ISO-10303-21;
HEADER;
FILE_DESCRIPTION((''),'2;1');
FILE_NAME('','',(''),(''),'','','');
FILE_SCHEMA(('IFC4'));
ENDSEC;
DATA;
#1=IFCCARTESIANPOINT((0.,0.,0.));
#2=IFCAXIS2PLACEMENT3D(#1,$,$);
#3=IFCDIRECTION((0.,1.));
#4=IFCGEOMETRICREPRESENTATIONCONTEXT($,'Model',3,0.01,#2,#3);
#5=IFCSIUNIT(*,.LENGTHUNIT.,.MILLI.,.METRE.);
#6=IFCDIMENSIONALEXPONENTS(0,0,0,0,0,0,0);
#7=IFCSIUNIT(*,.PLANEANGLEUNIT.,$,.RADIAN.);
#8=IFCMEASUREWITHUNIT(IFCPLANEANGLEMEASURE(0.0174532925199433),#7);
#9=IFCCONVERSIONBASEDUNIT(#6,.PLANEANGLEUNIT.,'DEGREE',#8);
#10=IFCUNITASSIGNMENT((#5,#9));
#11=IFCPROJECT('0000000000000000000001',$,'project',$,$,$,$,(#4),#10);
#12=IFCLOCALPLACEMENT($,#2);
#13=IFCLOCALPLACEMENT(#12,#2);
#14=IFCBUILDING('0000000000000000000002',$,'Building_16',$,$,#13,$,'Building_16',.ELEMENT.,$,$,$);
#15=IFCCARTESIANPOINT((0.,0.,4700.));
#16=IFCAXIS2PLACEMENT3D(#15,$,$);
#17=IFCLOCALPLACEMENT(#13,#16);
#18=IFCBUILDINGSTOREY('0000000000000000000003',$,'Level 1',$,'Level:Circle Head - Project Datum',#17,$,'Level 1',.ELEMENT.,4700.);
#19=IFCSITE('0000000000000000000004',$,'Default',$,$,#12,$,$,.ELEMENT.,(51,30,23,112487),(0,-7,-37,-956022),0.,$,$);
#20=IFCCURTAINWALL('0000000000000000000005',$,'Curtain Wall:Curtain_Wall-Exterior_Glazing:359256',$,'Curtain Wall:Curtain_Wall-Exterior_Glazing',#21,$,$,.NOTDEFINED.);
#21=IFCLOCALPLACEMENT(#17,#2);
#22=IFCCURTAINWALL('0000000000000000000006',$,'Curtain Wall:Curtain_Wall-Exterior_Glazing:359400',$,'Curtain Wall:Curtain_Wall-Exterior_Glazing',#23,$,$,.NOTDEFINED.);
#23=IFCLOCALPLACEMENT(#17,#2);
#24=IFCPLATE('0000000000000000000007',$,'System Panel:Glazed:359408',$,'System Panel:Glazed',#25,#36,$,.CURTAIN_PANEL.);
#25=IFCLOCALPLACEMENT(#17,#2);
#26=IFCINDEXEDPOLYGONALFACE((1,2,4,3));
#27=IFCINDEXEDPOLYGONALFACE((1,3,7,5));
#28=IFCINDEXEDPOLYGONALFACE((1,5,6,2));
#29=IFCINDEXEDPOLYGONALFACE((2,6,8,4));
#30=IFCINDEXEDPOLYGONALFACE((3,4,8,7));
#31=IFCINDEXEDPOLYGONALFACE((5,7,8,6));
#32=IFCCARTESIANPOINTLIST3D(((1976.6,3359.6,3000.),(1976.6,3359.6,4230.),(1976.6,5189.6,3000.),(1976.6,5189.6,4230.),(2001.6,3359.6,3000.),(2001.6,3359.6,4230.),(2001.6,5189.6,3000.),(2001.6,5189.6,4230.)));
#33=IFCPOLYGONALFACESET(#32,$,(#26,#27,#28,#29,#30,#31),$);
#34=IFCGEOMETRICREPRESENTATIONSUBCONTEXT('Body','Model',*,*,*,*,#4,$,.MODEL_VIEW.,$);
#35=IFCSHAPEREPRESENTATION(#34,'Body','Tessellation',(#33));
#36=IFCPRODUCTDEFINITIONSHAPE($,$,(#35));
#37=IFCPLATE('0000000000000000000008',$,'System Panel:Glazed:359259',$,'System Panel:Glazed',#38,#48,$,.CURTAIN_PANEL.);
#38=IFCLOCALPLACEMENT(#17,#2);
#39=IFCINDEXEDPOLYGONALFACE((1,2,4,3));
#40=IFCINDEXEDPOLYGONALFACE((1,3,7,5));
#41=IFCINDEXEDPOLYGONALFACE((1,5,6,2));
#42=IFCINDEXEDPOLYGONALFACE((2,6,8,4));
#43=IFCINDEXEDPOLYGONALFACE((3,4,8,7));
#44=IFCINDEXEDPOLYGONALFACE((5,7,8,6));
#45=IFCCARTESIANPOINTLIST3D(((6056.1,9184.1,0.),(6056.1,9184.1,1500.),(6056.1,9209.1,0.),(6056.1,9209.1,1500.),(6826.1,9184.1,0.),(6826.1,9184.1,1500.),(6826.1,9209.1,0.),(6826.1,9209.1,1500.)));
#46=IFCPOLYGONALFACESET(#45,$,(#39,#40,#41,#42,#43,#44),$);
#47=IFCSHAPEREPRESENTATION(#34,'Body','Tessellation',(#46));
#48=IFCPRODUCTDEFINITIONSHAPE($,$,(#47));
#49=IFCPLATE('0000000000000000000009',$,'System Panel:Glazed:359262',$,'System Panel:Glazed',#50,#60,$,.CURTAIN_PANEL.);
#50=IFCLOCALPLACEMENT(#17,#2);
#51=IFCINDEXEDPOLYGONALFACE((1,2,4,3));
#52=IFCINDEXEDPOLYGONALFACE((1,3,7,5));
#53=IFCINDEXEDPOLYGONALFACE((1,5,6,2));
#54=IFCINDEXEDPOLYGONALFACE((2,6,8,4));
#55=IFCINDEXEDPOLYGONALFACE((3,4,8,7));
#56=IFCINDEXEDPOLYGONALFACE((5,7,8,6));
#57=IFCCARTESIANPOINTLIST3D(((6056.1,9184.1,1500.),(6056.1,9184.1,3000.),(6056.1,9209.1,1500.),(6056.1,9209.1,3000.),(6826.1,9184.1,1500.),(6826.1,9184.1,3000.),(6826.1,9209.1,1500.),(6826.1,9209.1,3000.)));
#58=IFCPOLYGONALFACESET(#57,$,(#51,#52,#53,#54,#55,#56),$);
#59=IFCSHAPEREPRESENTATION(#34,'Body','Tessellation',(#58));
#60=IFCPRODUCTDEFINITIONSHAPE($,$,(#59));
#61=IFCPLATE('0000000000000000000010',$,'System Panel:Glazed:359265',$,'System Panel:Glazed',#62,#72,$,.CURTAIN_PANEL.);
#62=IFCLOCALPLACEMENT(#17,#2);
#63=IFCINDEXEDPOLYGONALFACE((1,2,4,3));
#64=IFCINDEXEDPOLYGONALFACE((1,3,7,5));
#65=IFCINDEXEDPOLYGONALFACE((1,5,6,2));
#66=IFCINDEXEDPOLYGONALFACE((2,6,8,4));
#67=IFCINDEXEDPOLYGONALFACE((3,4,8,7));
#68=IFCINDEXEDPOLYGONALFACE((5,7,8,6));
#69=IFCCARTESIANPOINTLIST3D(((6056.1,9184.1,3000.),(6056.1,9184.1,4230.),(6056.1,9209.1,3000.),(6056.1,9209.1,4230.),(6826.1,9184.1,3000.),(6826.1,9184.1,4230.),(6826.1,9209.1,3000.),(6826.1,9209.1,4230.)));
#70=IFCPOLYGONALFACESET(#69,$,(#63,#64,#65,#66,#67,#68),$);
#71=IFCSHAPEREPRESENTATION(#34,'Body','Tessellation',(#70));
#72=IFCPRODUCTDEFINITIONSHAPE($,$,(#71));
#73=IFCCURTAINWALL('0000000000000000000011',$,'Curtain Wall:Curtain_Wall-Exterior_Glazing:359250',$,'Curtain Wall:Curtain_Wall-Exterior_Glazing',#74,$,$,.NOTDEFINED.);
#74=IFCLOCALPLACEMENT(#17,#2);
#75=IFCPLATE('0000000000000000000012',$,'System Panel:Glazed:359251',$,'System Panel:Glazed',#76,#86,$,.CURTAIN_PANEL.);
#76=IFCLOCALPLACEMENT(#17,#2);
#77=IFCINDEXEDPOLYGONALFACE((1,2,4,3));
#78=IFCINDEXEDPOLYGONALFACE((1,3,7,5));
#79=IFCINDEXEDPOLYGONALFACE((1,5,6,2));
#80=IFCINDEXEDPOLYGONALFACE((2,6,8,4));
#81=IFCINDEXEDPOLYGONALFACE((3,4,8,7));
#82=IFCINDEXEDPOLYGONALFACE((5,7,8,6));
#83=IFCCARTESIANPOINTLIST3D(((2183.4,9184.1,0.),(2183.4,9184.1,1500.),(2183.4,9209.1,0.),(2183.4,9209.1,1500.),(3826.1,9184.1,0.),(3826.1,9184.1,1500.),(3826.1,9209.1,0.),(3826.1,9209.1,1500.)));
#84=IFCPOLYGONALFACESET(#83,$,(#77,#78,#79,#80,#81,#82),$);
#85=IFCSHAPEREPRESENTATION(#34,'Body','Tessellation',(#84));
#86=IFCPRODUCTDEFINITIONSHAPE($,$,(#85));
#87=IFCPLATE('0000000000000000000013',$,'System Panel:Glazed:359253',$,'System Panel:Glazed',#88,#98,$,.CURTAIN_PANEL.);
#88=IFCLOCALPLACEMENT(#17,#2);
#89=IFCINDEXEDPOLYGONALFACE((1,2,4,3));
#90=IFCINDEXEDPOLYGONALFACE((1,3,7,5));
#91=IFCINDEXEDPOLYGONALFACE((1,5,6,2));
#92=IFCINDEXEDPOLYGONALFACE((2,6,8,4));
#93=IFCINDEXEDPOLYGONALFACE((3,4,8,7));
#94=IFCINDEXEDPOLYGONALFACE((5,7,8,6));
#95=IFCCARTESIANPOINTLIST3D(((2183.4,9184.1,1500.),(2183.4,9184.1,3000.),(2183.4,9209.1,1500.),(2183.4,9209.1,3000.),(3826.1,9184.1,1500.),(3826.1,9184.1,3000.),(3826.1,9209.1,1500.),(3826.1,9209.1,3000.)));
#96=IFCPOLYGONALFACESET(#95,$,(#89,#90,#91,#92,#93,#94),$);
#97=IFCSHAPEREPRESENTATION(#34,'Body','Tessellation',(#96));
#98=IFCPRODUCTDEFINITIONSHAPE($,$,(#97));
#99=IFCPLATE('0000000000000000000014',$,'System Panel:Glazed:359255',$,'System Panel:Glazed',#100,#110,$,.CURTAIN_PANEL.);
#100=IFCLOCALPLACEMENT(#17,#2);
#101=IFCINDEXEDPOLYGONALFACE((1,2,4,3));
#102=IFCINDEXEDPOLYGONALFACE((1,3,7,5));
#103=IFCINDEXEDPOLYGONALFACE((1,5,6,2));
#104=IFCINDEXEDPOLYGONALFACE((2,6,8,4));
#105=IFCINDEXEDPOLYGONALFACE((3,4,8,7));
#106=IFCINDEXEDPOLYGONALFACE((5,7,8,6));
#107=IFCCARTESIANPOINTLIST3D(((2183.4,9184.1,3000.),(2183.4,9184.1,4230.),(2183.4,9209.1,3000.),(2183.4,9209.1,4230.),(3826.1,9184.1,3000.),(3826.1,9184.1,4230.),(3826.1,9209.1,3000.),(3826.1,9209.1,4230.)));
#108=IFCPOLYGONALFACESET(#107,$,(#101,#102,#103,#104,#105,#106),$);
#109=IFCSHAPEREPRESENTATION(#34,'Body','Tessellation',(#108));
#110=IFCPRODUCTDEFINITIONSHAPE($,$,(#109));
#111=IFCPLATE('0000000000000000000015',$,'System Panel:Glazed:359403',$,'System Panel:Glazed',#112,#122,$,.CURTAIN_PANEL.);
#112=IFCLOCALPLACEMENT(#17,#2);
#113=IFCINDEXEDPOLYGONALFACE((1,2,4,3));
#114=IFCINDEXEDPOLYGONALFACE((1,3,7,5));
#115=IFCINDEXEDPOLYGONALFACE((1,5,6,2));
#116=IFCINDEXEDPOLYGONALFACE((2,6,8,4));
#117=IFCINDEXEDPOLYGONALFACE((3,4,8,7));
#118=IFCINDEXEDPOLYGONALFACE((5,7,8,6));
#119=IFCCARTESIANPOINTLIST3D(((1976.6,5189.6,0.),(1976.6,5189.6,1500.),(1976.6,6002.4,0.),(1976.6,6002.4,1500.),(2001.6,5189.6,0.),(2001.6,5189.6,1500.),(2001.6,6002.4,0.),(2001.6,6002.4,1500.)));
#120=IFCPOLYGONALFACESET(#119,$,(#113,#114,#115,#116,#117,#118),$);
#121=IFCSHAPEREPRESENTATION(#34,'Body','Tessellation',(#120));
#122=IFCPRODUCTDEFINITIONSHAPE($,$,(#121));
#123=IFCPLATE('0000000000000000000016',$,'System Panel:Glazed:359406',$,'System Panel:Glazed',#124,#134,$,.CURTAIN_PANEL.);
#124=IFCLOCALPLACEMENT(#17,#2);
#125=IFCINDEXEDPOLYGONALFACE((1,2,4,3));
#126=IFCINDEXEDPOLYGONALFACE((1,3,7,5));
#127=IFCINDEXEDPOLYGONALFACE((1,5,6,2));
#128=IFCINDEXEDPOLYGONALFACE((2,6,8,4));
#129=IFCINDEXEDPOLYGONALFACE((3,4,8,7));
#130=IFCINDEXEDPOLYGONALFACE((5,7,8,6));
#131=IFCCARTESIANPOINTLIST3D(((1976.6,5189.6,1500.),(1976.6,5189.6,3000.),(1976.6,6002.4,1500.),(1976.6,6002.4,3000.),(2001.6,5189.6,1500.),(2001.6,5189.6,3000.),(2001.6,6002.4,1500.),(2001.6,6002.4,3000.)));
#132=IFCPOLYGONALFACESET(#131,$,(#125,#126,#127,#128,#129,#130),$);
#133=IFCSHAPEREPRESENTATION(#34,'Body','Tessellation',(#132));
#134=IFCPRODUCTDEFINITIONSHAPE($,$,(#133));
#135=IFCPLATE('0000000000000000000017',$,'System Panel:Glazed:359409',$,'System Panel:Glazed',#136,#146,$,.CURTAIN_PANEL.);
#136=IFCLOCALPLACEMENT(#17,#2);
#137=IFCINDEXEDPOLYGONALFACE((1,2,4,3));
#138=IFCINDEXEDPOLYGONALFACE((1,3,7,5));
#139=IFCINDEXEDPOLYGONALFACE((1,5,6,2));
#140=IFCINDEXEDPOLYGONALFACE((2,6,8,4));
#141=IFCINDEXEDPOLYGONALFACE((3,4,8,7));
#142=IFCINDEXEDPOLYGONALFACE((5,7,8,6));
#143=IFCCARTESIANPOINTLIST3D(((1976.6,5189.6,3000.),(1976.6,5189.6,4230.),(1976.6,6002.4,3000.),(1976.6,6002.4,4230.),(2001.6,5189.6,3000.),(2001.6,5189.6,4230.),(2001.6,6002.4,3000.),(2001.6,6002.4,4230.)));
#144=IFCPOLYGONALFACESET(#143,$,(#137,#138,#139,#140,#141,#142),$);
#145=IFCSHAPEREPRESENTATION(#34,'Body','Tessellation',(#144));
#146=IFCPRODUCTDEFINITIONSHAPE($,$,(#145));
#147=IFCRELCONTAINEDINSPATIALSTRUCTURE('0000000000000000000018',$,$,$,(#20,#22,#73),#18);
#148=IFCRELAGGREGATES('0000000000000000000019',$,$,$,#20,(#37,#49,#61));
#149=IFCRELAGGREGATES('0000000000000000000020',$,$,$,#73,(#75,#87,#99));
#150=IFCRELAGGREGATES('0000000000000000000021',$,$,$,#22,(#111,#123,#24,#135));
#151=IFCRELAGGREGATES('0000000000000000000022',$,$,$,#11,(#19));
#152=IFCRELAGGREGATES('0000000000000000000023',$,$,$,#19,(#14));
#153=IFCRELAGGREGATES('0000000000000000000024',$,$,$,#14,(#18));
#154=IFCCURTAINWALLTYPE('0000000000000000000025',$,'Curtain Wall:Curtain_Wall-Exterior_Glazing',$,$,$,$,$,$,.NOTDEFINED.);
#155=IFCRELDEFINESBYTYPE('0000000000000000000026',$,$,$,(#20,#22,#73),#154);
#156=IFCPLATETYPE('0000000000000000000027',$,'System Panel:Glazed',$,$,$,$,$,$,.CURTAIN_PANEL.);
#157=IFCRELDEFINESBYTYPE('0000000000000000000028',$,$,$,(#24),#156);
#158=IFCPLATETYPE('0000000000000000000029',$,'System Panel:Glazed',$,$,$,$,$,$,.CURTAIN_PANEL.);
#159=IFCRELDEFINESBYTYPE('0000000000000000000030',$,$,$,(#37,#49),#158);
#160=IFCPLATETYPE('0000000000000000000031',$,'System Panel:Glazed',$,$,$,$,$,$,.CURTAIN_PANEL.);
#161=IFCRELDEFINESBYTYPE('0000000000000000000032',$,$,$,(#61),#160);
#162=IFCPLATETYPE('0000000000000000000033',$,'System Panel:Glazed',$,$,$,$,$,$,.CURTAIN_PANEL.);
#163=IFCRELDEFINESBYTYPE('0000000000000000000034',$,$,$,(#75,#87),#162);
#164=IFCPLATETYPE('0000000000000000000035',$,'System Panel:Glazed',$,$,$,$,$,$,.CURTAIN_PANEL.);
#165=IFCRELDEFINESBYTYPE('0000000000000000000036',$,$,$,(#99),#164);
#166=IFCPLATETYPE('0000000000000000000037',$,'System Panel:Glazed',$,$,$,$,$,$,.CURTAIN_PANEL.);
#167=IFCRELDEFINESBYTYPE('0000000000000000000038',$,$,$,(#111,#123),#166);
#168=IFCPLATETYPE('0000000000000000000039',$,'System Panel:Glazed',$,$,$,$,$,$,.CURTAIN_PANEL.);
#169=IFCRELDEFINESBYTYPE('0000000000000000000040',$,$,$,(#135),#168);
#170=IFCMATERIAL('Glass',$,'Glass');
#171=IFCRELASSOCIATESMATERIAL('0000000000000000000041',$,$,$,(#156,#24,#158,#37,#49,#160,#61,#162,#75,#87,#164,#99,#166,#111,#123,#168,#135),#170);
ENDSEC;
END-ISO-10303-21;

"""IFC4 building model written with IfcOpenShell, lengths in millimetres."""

from ifc_helpers import new_model, entity, si_unit, converted_unit, direction, frame, origin, place, context, subcontext, project, spatial, indexed_curve, outline, extrude, source, transform, mapped, material, type_object, type_shapes, element, aggregate, save


model = new_model("IFC4")

# Units and contexts
model_context = context("Model", 3, precision=0.01, world=origin(), true_north=direction((0.0, 1.0)))
body_context = subcontext(model_context, "Body", "Model", "MODEL_VIEW")
ifc_project = project(units=[si_unit("LENGTHUNIT", "METRE", prefix="MILLI"), converted_unit("PLANEANGLEUNIT", "DEGREE", entity("IfcPlaneAngleMeasure", 0.0174532925199433), si_unit("PLANEANGLEUNIT", "RADIAN"), dimensions=[0, 0, 0, 0, 0, 0, 0])], contexts=[model_context])

# Site, building, storey
site_placement = place(None, origin())
site = spatial("IfcSite", under=ifc_project, at=site_placement, Name="Default", CompositionType="ELEMENT", RefLatitude=(51, 30, 23, 112487), RefLongitude=(0, -7, -37, -956022), RefElevation=0.0)
building_placement = place(site_placement, origin())
building = spatial("IfcBuilding", under=site, at=building_placement, Name="Building_16", LongName="Building_16", CompositionType="ELEMENT")
storey_placement = place(building_placement, frame((0.0, 0.0, 4700.0)))
storey = spatial("IfcBuildingStorey", under=building, at=storey_placement, Name="Level 1", ObjectType="Level:Circle Head - Project Datum", LongName="Level 1", CompositionType="ELEMENT", Elevation=4700.0)

# Curtain wall
curtain_wall_type = type_object("IfcCurtainWallType", Name="Curtain Wall:Curtain_Wall-Exterior_Glazing", PredefinedType="NOTDEFINED")
curtain_wall_1_placement = place(storey_placement, frame((0.0, 0.0, -4700.0)))
curtain_wall_1 = element("IfcCurtainWall", 1, at=curtain_wall_1_placement, inside=storey, type_object=curtain_wall_type, Name="Curtain Wall:Curtain_Wall-Exterior_Glazing:359256", ObjectType="Curtain Wall:Curtain_Wall-Exterior_Glazing", PredefinedType="NOTDEFINED")
ifc_material_1 = material(Name="Glass", Category="Glass")

# Shared definitions
plate_type_1 = type_object("IfcPlateType", Name="System Panel:Glazed", PredefinedType="CURTAIN_PANEL", material=ifc_material_1)
shared_shape_1 = source(origin(), body_context, "Body", "SweptSolid", [
    extrude(outline(indexed_curve([(-12.5, -915.0), (12.5, -915.0), (12.5, 915.0), (-12.5, 915.0), (-12.5, -915.0)], self_intersect=False)), frame((0.0, 37.0, 0.0), z_axis=(0.0, 0.0, 1.0), x_axis=(0.0, 1.0, 0.0)), (0.0, 0.0, 1.0), 1230.0),
])
type_shapes(plate_type_1, [shared_shape_1])

# Curtain wall, plate
curtain_wall_2_placement = place(storey_placement, frame((0.0, 0.0, -4700.0)))
curtain_wall_2 = element("IfcCurtainWall", 2, at=curtain_wall_2_placement, inside=storey, type_object=curtain_wall_type, Name="Curtain Wall:Curtain_Wall-Exterior_Glazing:359400", ObjectType="Curtain Wall:Curtain_Wall-Exterior_Glazing", PredefinedType="NOTDEFINED")
plate_1_placement = place(curtain_wall_2_placement, frame((2026.1, 4274.6, 7700.0), z_axis=(0.0, 0.0, 1.0), x_axis=(0.0, 1.0, 0.0)))
plate_1 = element("IfcPlate", 3, at=plate_1_placement, type_object=plate_type_1, material=ifc_material_1, Name="System Panel:Glazed:359408", ObjectType="System Panel:Glazed", PredefinedType="CURTAIN_PANEL", context=body_context, shape_type="MappedRepresentation", body=[
    mapped(shared_shape_1, transform((0.0, 0.0, 0.0), scale=1.0)),
])

# Plates
plate_type_2 = type_object("IfcPlateType", Name="System Panel:Glazed", PredefinedType="CURTAIN_PANEL", material=ifc_material_1)
shared_shape_2 = source(origin(), body_context, "Body", "SweptSolid", [
    extrude(outline(indexed_curve([(-12.5, -385.0), (12.5, -385.0), (12.5, 385.0), (-12.5, 385.0), (-12.5, -385.0)], self_intersect=False)), frame((0.0, 37.0, 0.0), z_axis=(0.0, 0.0, 1.0), x_axis=(0.0, 1.0, 0.0)), (0.0, 0.0, 1.0), 1500.0),
])
type_shapes(plate_type_2, [shared_shape_2])
plate_2_placement = place(curtain_wall_1_placement, frame((6441.1, 9159.6, 4700.0)))
plate_2 = element("IfcPlate", 4, at=plate_2_placement, type_object=plate_type_2, material=ifc_material_1, Name="System Panel:Glazed:359259", ObjectType="System Panel:Glazed", PredefinedType="CURTAIN_PANEL", context=body_context, shape_type="MappedRepresentation", body=[
    mapped(shared_shape_2, transform((0.0, 0.0, 0.0), scale=1.0)),
])
plate_3_placement = place(curtain_wall_1_placement, frame((6441.1, 9159.6, 6200.0)))
plate_3 = element("IfcPlate", 5, at=plate_3_placement, type_object=plate_type_2, material=ifc_material_1, Name="System Panel:Glazed:359262", ObjectType="System Panel:Glazed", PredefinedType="CURTAIN_PANEL", context=body_context, shape_type="MappedRepresentation", body=[
    mapped(shared_shape_2, transform((0.0, 0.0, 0.0), scale=1.0)),
])
plate_type_3 = type_object("IfcPlateType", Name="System Panel:Glazed", PredefinedType="CURTAIN_PANEL", material=ifc_material_1)
shared_shape_3 = source(origin(), body_context, "Body", "SweptSolid", [
    extrude(outline(indexed_curve([(-12.5, -385.0), (12.5, -385.0), (12.5, 385.0), (-12.5, 385.0), (-12.5, -385.0)], self_intersect=False)), frame((0.0, 37.0, 0.0), z_axis=(0.0, 0.0, 1.0), x_axis=(0.0, 1.0, 0.0)), (0.0, 0.0, 1.0), 1230.0),
])
type_shapes(plate_type_3, [shared_shape_3])
plate_4_placement = place(curtain_wall_1_placement, frame((6441.1, 9159.6, 7700.0)))
plate_4 = element("IfcPlate", 6, at=plate_4_placement, type_object=plate_type_3, material=ifc_material_1, Name="System Panel:Glazed:359265", ObjectType="System Panel:Glazed", PredefinedType="CURTAIN_PANEL", context=body_context, shape_type="MappedRepresentation", body=[
    mapped(shared_shape_3, transform((0.0, 0.0, 0.0), scale=1.0)),
])
aggregate(curtain_wall_1, [plate_2, plate_3, plate_4])

# Curtain wall, plates
curtain_wall_3_placement = place(storey_placement, frame((0.0, 0.0, -4700.0)))
curtain_wall_3 = element("IfcCurtainWall", 7, at=curtain_wall_3_placement, inside=storey, type_object=curtain_wall_type, Name="Curtain Wall:Curtain_Wall-Exterior_Glazing:359250", ObjectType="Curtain Wall:Curtain_Wall-Exterior_Glazing", PredefinedType="NOTDEFINED")
plate_type_4 = type_object("IfcPlateType", Name="System Panel:Glazed", PredefinedType="CURTAIN_PANEL", material=ifc_material_1)
shared_shape_4 = source(origin(), body_context, "Body", "SweptSolid", [
    extrude(outline(indexed_curve([(-12.5, -821.4), (12.5, -821.4), (12.5, 821.4), (-12.5, 821.4), (-12.5, -821.4)], self_intersect=False)), frame((0.0, 37.0, 0.0), z_axis=(0.0, 0.0, 1.0), x_axis=(0.0, 1.0, 0.0)), (0.0, 0.0, 1.0), 1500.0),
])
type_shapes(plate_type_4, [shared_shape_4])
plate_5_placement = place(curtain_wall_3_placement, frame((3004.7, 9159.6, 4700.0)))
plate_5 = element("IfcPlate", 8, at=plate_5_placement, type_object=plate_type_4, material=ifc_material_1, Name="System Panel:Glazed:359251", ObjectType="System Panel:Glazed", PredefinedType="CURTAIN_PANEL", context=body_context, shape_type="MappedRepresentation", body=[
    mapped(shared_shape_4, transform((0.0, 0.0, 0.0), scale=1.0)),
])
plate_6_placement = place(curtain_wall_3_placement, frame((3004.7, 9159.6, 6200.0)))
plate_6 = element("IfcPlate", 9, at=plate_6_placement, type_object=plate_type_4, material=ifc_material_1, Name="System Panel:Glazed:359253", ObjectType="System Panel:Glazed", PredefinedType="CURTAIN_PANEL", context=body_context, shape_type="MappedRepresentation", body=[
    mapped(shared_shape_4, transform((0.0, 0.0, 0.0), scale=1.0)),
])
plate_type_5 = type_object("IfcPlateType", Name="System Panel:Glazed", PredefinedType="CURTAIN_PANEL", material=ifc_material_1)
shared_shape_5 = source(origin(), body_context, "Body", "SweptSolid", [
    extrude(outline(indexed_curve([(-12.5, -821.4), (12.5, -821.4), (12.5, 821.4), (-12.5, 821.4), (-12.5, -821.4)], self_intersect=False)), frame((0.0, 37.0, 0.0), z_axis=(0.0, 0.0, 1.0), x_axis=(0.0, 1.0, 0.0)), (0.0, 0.0, 1.0), 1230.0),
])
type_shapes(plate_type_5, [shared_shape_5])
plate_7_placement = place(curtain_wall_3_placement, frame((3004.7, 9159.6, 7700.0)))
plate_7 = element("IfcPlate", 10, at=plate_7_placement, type_object=plate_type_5, material=ifc_material_1, Name="System Panel:Glazed:359255", ObjectType="System Panel:Glazed", PredefinedType="CURTAIN_PANEL", context=body_context, shape_type="MappedRepresentation", body=[
    mapped(shared_shape_5, transform((0.0, 0.0, 0.0), scale=1.0)),
])
aggregate(curtain_wall_3, [plate_5, plate_6, plate_7])

# Plates
plate_type_6 = type_object("IfcPlateType", Name="System Panel:Glazed", PredefinedType="CURTAIN_PANEL", material=ifc_material_1)
shared_shape_6 = source(origin(), body_context, "Body", "SweptSolid", [
    extrude(outline(indexed_curve([(-12.5, -406.4), (12.5, -406.4), (12.5, 406.4), (-12.5, 406.4), (-12.5, -406.4)], self_intersect=False)), frame((0.0, 37.0, 0.0), z_axis=(0.0, 0.0, 1.0), x_axis=(0.0, 1.0, 0.0)), (0.0, 0.0, 1.0), 1500.0),
])
type_shapes(plate_type_6, [shared_shape_6])
plate_8_placement = place(curtain_wall_2_placement, frame((2026.1, 5596.0, 4700.0), z_axis=(0.0, 0.0, 1.0), x_axis=(0.0, 1.0, 0.0)))
plate_8 = element("IfcPlate", 11, at=plate_8_placement, type_object=plate_type_6, material=ifc_material_1, Name="System Panel:Glazed:359403", ObjectType="System Panel:Glazed", PredefinedType="CURTAIN_PANEL", context=body_context, shape_type="MappedRepresentation", body=[
    mapped(shared_shape_6, transform((0.0, 0.0, 0.0), scale=1.0)),
])
plate_9_placement = place(curtain_wall_2_placement, frame((2026.1, 5596.0, 6200.0), z_axis=(0.0, 0.0, 1.0), x_axis=(0.0, 1.0, 0.0)))
plate_9 = element("IfcPlate", 12, at=plate_9_placement, type_object=plate_type_6, material=ifc_material_1, Name="System Panel:Glazed:359406", ObjectType="System Panel:Glazed", PredefinedType="CURTAIN_PANEL", context=body_context, shape_type="MappedRepresentation", body=[
    mapped(shared_shape_6, transform((0.0, 0.0, 0.0), scale=1.0)),
])
plate_type_7 = type_object("IfcPlateType", Name="System Panel:Glazed", PredefinedType="CURTAIN_PANEL", material=ifc_material_1)
shared_shape_7 = source(origin(), body_context, "Body", "SweptSolid", [
    extrude(outline(indexed_curve([(-12.5, -406.4), (12.5, -406.4), (12.5, 406.4), (-12.5, 406.4), (-12.5, -406.4)], self_intersect=False)), frame((0.0, 37.0, 0.0), z_axis=(0.0, 0.0, 1.0), x_axis=(0.0, 1.0, 0.0)), (0.0, 0.0, 1.0), 1230.0),
])
type_shapes(plate_type_7, [shared_shape_7])
plate_10_placement = place(curtain_wall_2_placement, frame((2026.1, 5596.0, 7700.0), z_axis=(0.0, 0.0, 1.0), x_axis=(0.0, 1.0, 0.0)))
plate_10 = element("IfcPlate", 13, at=plate_10_placement, type_object=plate_type_7, material=ifc_material_1, Name="System Panel:Glazed:359409", ObjectType="System Panel:Glazed", PredefinedType="CURTAIN_PANEL", context=body_context, shape_type="MappedRepresentation", body=[
    mapped(shared_shape_7, transform((0.0, 0.0, 0.0), scale=1.0)),
])
aggregate(curtain_wall_2, [plate_8, plate_9, plate_1, plate_10])

save(model, "model.ifc")
